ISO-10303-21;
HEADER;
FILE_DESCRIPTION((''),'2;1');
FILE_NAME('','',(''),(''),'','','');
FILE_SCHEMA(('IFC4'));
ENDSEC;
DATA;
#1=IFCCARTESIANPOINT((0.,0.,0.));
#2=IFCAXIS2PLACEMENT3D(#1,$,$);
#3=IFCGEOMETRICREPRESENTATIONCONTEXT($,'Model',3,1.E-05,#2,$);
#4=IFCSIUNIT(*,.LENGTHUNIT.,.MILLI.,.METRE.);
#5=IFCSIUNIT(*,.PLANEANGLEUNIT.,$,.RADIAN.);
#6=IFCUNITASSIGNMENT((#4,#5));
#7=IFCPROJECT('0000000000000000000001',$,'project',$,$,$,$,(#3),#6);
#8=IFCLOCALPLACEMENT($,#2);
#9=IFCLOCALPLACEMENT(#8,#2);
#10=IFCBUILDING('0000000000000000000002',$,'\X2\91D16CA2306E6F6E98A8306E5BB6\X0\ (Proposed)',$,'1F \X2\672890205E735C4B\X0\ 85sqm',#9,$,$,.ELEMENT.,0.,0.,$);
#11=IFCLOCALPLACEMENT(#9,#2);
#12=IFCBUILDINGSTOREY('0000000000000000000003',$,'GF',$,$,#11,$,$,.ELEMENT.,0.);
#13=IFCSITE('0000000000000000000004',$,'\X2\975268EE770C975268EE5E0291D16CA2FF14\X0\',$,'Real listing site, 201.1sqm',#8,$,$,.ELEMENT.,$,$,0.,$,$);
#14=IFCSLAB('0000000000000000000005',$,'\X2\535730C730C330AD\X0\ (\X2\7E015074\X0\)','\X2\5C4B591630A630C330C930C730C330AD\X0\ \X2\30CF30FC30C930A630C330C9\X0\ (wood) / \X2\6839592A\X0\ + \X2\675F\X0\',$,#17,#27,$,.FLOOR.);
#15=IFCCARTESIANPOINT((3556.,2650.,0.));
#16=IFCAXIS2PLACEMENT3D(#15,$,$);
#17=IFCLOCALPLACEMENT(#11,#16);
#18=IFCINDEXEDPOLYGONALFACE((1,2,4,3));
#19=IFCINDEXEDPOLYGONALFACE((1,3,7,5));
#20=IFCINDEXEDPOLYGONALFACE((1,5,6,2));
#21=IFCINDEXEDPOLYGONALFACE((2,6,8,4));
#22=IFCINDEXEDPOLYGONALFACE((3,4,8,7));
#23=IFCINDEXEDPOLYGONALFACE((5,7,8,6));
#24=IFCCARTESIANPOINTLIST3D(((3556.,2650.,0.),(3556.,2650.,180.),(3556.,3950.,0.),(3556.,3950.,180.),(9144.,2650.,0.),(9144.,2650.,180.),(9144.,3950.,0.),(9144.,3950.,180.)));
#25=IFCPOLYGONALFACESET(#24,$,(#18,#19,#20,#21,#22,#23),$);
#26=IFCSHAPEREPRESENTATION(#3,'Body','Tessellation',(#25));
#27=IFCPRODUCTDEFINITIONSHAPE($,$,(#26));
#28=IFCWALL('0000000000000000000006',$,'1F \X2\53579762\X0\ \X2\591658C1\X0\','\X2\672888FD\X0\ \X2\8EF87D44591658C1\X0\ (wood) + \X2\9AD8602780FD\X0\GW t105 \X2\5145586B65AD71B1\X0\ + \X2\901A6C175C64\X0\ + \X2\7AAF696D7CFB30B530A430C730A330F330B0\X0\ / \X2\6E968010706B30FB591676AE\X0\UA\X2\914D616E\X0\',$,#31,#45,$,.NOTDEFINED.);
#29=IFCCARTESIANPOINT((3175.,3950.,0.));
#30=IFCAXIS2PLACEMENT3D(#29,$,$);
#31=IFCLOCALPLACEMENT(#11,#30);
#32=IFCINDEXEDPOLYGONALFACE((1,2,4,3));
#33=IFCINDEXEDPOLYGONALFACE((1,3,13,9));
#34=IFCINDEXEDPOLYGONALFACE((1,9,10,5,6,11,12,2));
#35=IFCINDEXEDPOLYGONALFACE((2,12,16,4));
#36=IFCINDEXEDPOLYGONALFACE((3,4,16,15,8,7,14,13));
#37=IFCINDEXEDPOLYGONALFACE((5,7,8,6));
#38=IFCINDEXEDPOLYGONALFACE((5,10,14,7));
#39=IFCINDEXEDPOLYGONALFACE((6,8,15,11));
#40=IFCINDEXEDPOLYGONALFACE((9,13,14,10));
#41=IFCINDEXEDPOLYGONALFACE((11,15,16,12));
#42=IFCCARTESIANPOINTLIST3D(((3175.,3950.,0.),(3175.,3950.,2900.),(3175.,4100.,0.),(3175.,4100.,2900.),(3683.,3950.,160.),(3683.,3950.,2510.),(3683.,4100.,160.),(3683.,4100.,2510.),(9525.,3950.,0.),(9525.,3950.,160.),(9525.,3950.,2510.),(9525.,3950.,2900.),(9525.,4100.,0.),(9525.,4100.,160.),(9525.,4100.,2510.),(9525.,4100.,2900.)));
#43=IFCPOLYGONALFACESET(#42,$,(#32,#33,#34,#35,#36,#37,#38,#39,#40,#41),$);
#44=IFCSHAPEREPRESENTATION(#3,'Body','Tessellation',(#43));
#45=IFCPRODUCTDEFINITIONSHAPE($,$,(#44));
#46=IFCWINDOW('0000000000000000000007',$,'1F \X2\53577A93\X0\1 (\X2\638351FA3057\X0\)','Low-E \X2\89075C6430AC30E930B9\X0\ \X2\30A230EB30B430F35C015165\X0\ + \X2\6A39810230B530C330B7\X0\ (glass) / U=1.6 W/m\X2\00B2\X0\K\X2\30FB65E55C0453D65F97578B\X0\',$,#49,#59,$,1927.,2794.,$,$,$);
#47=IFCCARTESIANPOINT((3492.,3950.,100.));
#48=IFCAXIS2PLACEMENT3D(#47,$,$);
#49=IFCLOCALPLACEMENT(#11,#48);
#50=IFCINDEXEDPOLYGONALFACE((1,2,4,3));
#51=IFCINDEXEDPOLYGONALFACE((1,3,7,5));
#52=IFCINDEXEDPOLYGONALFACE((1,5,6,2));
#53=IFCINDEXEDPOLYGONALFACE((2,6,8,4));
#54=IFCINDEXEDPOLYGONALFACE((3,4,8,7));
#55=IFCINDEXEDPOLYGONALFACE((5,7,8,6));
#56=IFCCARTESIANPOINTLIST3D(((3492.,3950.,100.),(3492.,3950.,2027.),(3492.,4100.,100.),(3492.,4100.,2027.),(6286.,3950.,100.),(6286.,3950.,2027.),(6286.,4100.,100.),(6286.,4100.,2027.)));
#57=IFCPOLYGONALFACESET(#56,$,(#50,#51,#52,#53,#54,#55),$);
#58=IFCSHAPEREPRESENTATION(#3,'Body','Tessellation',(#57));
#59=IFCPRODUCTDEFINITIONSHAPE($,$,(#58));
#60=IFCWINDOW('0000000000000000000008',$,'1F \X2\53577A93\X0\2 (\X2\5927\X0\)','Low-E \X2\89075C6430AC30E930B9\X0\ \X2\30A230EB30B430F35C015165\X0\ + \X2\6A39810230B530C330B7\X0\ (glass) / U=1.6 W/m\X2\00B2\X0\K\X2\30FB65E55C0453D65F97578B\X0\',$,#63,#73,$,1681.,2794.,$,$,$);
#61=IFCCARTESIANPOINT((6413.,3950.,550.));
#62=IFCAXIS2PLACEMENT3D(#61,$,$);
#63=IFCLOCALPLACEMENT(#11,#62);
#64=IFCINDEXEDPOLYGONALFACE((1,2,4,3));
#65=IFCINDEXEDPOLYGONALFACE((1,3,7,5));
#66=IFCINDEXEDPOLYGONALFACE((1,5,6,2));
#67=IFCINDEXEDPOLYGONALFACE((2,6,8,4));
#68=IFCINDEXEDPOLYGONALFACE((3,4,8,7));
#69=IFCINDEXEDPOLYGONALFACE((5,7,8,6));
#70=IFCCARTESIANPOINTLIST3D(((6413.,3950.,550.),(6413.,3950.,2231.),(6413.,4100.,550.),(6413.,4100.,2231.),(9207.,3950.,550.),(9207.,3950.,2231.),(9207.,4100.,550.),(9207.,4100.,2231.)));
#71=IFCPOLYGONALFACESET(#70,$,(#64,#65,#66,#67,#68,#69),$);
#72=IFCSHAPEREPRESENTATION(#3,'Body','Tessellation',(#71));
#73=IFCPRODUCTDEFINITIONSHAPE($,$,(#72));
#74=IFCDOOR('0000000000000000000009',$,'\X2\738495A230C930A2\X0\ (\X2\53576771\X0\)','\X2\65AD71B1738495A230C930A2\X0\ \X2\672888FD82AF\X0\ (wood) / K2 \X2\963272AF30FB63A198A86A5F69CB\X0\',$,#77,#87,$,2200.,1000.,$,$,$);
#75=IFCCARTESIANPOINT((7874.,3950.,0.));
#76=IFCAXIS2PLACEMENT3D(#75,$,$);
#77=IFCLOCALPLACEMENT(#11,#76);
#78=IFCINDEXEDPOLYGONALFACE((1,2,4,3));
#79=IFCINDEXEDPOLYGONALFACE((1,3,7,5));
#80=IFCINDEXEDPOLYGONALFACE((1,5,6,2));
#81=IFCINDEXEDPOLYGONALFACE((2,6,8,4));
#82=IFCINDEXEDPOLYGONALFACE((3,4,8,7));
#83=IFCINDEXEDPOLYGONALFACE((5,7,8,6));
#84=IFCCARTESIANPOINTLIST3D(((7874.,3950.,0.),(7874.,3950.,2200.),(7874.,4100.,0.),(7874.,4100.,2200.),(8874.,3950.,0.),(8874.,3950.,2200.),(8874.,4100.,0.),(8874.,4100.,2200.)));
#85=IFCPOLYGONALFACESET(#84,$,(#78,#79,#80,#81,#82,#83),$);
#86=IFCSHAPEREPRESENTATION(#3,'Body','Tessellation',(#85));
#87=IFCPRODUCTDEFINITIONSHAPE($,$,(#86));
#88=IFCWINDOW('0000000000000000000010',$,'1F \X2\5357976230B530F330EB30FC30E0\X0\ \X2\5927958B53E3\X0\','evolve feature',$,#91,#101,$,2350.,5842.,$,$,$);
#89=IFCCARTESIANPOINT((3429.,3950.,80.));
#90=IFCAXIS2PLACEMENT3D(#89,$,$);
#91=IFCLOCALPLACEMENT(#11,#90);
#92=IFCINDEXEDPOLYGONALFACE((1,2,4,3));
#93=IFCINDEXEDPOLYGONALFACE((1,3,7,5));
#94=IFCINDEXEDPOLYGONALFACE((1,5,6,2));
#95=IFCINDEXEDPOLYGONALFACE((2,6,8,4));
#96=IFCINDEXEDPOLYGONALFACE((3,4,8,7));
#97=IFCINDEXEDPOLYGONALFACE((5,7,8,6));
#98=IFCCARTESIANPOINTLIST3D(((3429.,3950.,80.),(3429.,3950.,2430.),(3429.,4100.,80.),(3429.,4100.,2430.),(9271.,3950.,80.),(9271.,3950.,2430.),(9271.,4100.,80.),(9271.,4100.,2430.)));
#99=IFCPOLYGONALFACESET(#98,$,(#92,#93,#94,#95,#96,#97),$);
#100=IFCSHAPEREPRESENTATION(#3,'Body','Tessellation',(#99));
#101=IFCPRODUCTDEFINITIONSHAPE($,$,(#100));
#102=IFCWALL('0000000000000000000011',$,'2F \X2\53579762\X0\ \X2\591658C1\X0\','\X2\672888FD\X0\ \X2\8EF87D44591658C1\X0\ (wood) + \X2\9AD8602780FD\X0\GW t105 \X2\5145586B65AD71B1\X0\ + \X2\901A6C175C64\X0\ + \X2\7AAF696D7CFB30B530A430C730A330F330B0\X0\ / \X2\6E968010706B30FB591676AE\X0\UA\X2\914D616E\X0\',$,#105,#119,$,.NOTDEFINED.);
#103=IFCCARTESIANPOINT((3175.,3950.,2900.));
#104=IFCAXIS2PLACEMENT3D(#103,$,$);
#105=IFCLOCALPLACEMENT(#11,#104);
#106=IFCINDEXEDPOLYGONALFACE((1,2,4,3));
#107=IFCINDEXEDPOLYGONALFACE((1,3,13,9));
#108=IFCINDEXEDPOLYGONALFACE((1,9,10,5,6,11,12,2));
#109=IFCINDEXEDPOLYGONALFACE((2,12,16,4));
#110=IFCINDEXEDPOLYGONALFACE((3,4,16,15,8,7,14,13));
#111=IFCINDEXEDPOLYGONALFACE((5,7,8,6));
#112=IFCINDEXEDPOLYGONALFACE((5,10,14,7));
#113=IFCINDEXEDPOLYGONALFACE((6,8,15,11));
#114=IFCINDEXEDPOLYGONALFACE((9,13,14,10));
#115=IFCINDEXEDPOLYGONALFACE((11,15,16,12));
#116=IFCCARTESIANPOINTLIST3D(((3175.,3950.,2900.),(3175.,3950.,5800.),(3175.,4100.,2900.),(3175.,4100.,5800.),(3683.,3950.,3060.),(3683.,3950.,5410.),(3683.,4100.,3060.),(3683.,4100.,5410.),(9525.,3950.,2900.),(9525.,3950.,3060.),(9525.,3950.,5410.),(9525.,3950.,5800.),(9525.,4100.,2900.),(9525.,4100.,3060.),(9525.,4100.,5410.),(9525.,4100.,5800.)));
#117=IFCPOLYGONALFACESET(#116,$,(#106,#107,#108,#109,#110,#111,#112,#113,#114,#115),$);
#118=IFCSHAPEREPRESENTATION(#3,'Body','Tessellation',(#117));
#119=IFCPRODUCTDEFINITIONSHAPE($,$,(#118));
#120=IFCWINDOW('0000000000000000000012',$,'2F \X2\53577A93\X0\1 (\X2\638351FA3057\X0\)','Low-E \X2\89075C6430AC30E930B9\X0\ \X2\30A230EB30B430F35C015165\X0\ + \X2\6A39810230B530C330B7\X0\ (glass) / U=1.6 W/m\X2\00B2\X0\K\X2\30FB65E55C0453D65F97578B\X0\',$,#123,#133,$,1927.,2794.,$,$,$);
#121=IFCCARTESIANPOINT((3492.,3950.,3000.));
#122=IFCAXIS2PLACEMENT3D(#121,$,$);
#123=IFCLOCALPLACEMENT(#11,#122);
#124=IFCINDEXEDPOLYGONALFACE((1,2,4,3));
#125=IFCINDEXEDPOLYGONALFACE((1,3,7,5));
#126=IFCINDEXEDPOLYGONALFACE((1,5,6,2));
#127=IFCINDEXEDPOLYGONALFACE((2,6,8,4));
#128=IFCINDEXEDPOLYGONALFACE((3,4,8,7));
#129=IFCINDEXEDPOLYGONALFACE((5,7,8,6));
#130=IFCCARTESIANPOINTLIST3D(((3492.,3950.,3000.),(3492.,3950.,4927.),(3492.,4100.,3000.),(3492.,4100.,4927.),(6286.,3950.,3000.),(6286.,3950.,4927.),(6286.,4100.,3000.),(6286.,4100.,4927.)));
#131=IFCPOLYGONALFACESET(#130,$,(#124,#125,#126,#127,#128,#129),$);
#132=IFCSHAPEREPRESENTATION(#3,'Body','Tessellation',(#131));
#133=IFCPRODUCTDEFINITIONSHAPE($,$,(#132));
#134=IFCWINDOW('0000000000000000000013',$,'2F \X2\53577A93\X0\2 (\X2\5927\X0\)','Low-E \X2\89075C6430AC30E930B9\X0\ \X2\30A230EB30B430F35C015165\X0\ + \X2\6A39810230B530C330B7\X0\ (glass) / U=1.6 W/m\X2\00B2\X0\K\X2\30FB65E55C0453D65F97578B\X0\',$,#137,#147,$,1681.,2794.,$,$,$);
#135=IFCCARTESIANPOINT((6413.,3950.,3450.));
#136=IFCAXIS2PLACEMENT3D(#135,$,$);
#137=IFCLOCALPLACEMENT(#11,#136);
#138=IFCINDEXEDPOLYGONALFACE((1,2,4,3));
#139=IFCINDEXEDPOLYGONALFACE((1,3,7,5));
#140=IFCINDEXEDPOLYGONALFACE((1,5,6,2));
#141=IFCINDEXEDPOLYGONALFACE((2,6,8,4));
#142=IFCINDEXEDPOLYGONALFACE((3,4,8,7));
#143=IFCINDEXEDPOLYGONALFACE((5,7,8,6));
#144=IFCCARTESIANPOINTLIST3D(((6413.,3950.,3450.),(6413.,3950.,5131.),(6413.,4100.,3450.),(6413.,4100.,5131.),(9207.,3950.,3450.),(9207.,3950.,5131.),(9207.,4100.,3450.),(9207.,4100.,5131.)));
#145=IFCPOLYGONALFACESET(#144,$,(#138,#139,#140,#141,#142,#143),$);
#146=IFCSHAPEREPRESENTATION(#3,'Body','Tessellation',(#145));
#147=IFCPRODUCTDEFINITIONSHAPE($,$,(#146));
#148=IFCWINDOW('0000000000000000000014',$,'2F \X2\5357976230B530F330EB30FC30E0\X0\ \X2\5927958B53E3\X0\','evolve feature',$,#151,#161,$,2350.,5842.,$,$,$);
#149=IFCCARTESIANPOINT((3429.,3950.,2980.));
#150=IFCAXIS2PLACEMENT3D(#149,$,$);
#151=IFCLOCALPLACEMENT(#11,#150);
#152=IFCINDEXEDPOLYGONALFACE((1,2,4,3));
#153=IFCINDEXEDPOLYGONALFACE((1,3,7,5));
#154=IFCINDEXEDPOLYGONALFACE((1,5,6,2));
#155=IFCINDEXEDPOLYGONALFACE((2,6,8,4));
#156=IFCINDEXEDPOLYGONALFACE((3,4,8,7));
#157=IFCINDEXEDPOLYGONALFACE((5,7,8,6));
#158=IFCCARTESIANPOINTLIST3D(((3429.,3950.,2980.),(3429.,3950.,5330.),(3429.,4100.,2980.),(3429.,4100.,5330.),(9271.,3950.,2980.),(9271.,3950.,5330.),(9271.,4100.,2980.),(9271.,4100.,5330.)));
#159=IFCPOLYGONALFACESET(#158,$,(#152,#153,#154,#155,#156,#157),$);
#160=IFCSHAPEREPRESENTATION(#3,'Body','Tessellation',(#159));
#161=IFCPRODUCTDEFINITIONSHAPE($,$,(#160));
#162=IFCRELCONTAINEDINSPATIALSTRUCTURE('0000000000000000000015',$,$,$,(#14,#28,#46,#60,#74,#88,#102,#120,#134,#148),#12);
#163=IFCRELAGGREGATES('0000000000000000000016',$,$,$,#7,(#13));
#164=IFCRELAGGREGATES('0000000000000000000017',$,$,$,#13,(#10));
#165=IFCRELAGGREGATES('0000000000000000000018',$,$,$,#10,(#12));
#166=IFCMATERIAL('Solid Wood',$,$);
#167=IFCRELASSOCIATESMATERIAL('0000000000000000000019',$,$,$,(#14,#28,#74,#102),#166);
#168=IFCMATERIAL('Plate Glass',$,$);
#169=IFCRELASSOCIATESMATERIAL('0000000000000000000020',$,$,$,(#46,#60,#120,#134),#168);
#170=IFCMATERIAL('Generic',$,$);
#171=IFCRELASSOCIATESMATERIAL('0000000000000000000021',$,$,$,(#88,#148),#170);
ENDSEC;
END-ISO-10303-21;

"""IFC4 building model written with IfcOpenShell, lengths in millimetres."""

from ifc_helpers import new_model, si_unit, frame, frame_2d, origin, place, context, project, spatial, rectangle, extrude, material, element, fill, save


model = new_model("IFC4")

# Units and contexts
model_context = context("Model", 3, precision=1e-05, world=origin())
ifc_project = project(units=[si_unit("LENGTHUNIT", "METRE", prefix="MILLI"), si_unit("PLANEANGLEUNIT", "RADIAN")], contexts=[model_context])

# Site, building, storey
site_placement = place(None, origin())
site = spatial("IfcSite", under=ifc_project, at=site_placement, Name="青森県青森市金沢４", ObjectType="Real listing site, 201.1sqm", CompositionType="ELEMENT", RefElevation=0.0)
building_placement = place(site_placement, origin())
building = spatial("IfcBuilding", under=site, at=building_placement, Name="金沢の潮風の家 (Proposed)", ObjectType="1F 木造平屋 85sqm", CompositionType="ELEMENT", ElevationOfRefHeight=0.0, ElevationOfTerrain=0.0)
storey_placement = place(building_placement, origin())
storey = spatial("IfcBuildingStorey", under=building, at=storey_placement, Name="GF", CompositionType="ELEMENT", Elevation=0.0)

# Slab
ifc_material_1 = material(Name="Solid Wood")
slab_1_placement = place(storey_placement, frame((3556.0, 2650.0, 0.0)))
element("IfcSlab", 1, at=slab_1_placement, inside=storey, material=ifc_material_1, Name="南デッキ (縁側)", Description="屋外ウッドデッキ ハードウッド (wood) / 根太 + 束", PredefinedType="FLOOR", context=model_context, shape_type="SweptSolid", body=[
    extrude(rectangle(XDim=5588.0, YDim=1300.0, at=frame_2d((2794.0, 650.0))), frame((3556.0, 2650.0, 0.0)), (0.0, 0.0, 1.0), 180.0),
])
ifc_material_2 = material(Name="Generic")

# Wall, openings, windows, door
wall_1_placement = place(storey_placement, frame((3175.0, 3950.0, 0.0)))
wall_1 = element("IfcWall", 2, at=wall_1_placement, inside=storey, material=ifc_material_1, Name="1F 南面 外壁", Description="木製 軸組外壁 (wood) + 高性能GW t105 充填断熱 + 通気層 + 窯業系サイディング / 準耐火・外皮UA配慮", PredefinedType="NOTDEFINED", context=model_context, shape_type="SweptSolid", body=[
    extrude(rectangle(XDim=6350.0, YDim=150.0, at=frame_2d((3175.0, 75.0))), frame((3175.0, 3950.0, 0.0)), (0.0, 0.0, 1.0), 2900.0),
])
opening_1_placement = place(storey_placement, frame((3492.0, 3950.0, 100.0)))
opening_1 = element("IfcOpeningElement", 3, at=opening_1_placement, cuts=wall_1, PredefinedType="NOTDEFINED", context=model_context, shape_type="SweptSolid", body=[
    extrude(rectangle(XDim=2794.0, YDim=150.0, at=frame_2d((1397.0, 75.0))), frame((3492.0, 3950.0, 100.0)), (0.0, 0.0, 1.0), 1927.0),
])
opening_2_placement = place(storey_placement, frame((6413.0, 3950.0, 550.0)))
opening_2 = element("IfcOpeningElement", 4, at=opening_2_placement, cuts=wall_1, PredefinedType="NOTDEFINED", context=model_context, shape_type="SweptSolid", body=[
    extrude(rectangle(XDim=2794.0, YDim=150.0, at=frame_2d((1397.0, 75.0))), frame((6413.0, 3950.0, 550.0)), (0.0, 0.0, 1.0), 1681.0),
])
opening_3_placement = place(storey_placement, frame((7874.0, 3950.0, 0.0)))
opening_3 = element("IfcOpeningElement", 5, at=opening_3_placement, cuts=wall_1, PredefinedType="NOTDEFINED", context=model_context, shape_type="SweptSolid", body=[
    extrude(rectangle(XDim=1000.0, YDim=150.0, at=frame_2d((500.0, 75.0))), frame((7874.0, 3950.0, 0.0)), (0.0, 0.0, 1.0), 2200.0),
])
opening_4_placement = place(storey_placement, frame((3429.0, 3950.0, 80.0)))
opening_4 = element("IfcOpeningElement", 6, at=opening_4_placement, cuts=wall_1, PredefinedType="NOTDEFINED", context=model_context, shape_type="SweptSolid", body=[
    extrude(rectangle(XDim=5842.0, YDim=150.0, at=frame_2d((2921.0, 75.0))), frame((3429.0, 3950.0, 80.0)), (0.0, 0.0, 1.0), 2350.0),
])
ifc_material_3 = material(Name="Plate Glass")
window_1_placement = place(storey_placement, frame((3492.0, 3950.0, 100.0)))
window_1 = element("IfcWindow", 7, at=window_1_placement, inside=storey, material=ifc_material_3, Name="1F 南窓1 (掃出し)", Description="Low-E 複層ガラス アルゴン封入 + 樹脂サッシ (glass) / U=1.6 W/m²K・日射取得型", OverallHeight=1927.0, OverallWidth=2794.0, context=model_context, shape_type="SweptSolid", body=[
    extrude(rectangle(XDim=2794.0, YDim=150.0, at=frame_2d((1397.0, 75.0))), frame((3492.0, 3950.0, 100.0)), (0.0, 0.0, 1.0), 1927.0),
])
fill(opening_1, window_1)
window_2_placement = place(storey_placement, frame((6413.0, 3950.0, 550.0)))
window_2 = element("IfcWindow", 8, at=window_2_placement, inside=storey, material=ifc_material_3, Name="1F 南窓2 (大)", Description="Low-E 複層ガラス アルゴン封入 + 樹脂サッシ (glass) / U=1.6 W/m²K・日射取得型", OverallHeight=1681.0, OverallWidth=2794.0, context=model_context, shape_type="SweptSolid", body=[
    extrude(rectangle(XDim=2794.0, YDim=150.0, at=frame_2d((1397.0, 75.0))), frame((6413.0, 3950.0, 550.0)), (0.0, 0.0, 1.0), 1681.0),
])
fill(opening_2, window_2)
door_placement = place(storey_placement, frame((7874.0, 3950.0, 0.0)))
door = element("IfcDoor", 9, at=door_placement, inside=storey, material=ifc_material_1, Name="玄関ドア (南東)", Description="断熱玄関ドア 木製芯 (wood) / K2 防犯・採風機構", OverallHeight=2200.0, OverallWidth=1000.0, context=model_context, shape_type="SweptSolid", body=[
    extrude(rectangle(XDim=1000.0, YDim=150.0, at=frame_2d((500.0, 75.0))), frame((7874.0, 3950.0, 0.0)), (0.0, 0.0, 1.0), 2200.0),
])
fill(opening_3, door)
window_3_placement = place(storey_placement, frame((3429.0, 3950.0, 80.0)))
window_3 = element("IfcWindow", 10, at=window_3_placement, inside=storey, material=ifc_material_2, Name="1F 南面サンルーム 大開口", Description="evolve feature", OverallHeight=2350.0, OverallWidth=5842.0, context=model_context, shape_type="SweptSolid", body=[
    extrude(rectangle(XDim=5842.0, YDim=150.0, at=frame_2d((2921.0, 75.0))), frame((3429.0, 3950.0, 80.0)), (0.0, 0.0, 1.0), 2350.0),
])
fill(opening_4, window_3)

# Wall, openings, windows
wall_2_placement = place(storey_placement, frame((3175.0, 3950.0, 2900.0)))
wall_2 = element("IfcWall", 11, at=wall_2_placement, inside=storey, material=ifc_material_1, Name="2F 南面 外壁", Description="木製 軸組外壁 (wood) + 高性能GW t105 充填断熱 + 通気層 + 窯業系サイディング / 準耐火・外皮UA配慮", PredefinedType="NOTDEFINED", context=model_context, shape_type="SweptSolid", body=[
    extrude(rectangle(XDim=6350.0, YDim=150.0, at=frame_2d((3175.0, 75.0))), frame((3175.0, 3950.0, 2900.0)), (0.0, 0.0, 1.0), 2900.0),
])
opening_5_placement = place(storey_placement, frame((3492.0, 3950.0, 3000.0)))
opening_5 = element("IfcOpeningElement", 12, at=opening_5_placement, cuts=wall_2, PredefinedType="NOTDEFINED", context=model_context, shape_type="SweptSolid", body=[
    extrude(rectangle(XDim=2794.0, YDim=150.0, at=frame_2d((1397.0, 75.0))), frame((3492.0, 3950.0, 3000.0)), (0.0, 0.0, 1.0), 1927.0),
])
opening_6_placement = place(storey_placement, frame((6413.0, 3950.0, 3450.0)))
opening_6 = element("IfcOpeningElement", 13, at=opening_6_placement, cuts=wall_2, PredefinedType="NOTDEFINED", context=model_context, shape_type="SweptSolid", body=[
    extrude(rectangle(XDim=2794.0, YDim=150.0, at=frame_2d((1397.0, 75.0))), frame((6413.0, 3950.0, 3450.0)), (0.0, 0.0, 1.0), 1681.0),
])
opening_7_placement = place(storey_placement, frame((3429.0, 3950.0, 2980.0)))
opening_7 = element("IfcOpeningElement", 14, at=opening_7_placement, cuts=wall_2, PredefinedType="NOTDEFINED", context=model_context, shape_type="SweptSolid", body=[
    extrude(rectangle(XDim=5842.0, YDim=150.0, at=frame_2d((2921.0, 75.0))), frame((3429.0, 3950.0, 2980.0)), (0.0, 0.0, 1.0), 2350.0),
])
window_4_placement = place(storey_placement, frame((3492.0, 3950.0, 3000.0)))
window_4 = element("IfcWindow", 15, at=window_4_placement, inside=storey, material=ifc_material_3, Name="2F 南窓1 (掃出し)", Description="Low-E 複層ガラス アルゴン封入 + 樹脂サッシ (glass) / U=1.6 W/m²K・日射取得型", OverallHeight=1927.0, OverallWidth=2794.0, context=model_context, shape_type="SweptSolid", body=[
    extrude(rectangle(XDim=2794.0, YDim=150.0, at=frame_2d((1397.0, 75.0))), frame((3492.0, 3950.0, 3000.0)), (0.0, 0.0, 1.0), 1927.0),
])
fill(opening_5, window_4)
window_5_placement = place(storey_placement, frame((6413.0, 3950.0, 3450.0)))
window_5 = element("IfcWindow", 16, at=window_5_placement, inside=storey, material=ifc_material_3, Name="2F 南窓2 (大)", Description="Low-E 複層ガラス アルゴン封入 + 樹脂サッシ (glass) / U=1.6 W/m²K・日射取得型", OverallHeight=1681.0, OverallWidth=2794.0, context=model_context, shape_type="SweptSolid", body=[
    extrude(rectangle(XDim=2794.0, YDim=150.0, at=frame_2d((1397.0, 75.0))), frame((6413.0, 3950.0, 3450.0)), (0.0, 0.0, 1.0), 1681.0),
])
fill(opening_6, window_5)
window_6_placement = place(storey_placement, frame((3429.0, 3950.0, 2980.0)))
window_6 = element("IfcWindow", 17, at=window_6_placement, inside=storey, material=ifc_material_2, Name="2F 南面サンルーム 大開口", Description="evolve feature", OverallHeight=2350.0, OverallWidth=5842.0, context=model_context, shape_type="SweptSolid", body=[
    extrude(rectangle(XDim=5842.0, YDim=150.0, at=frame_2d((2921.0, 75.0))), frame((3429.0, 3950.0, 2980.0)), (0.0, 0.0, 1.0), 2350.0),
])
fill(opening_7, window_6)

save(model, "model.ifc")
